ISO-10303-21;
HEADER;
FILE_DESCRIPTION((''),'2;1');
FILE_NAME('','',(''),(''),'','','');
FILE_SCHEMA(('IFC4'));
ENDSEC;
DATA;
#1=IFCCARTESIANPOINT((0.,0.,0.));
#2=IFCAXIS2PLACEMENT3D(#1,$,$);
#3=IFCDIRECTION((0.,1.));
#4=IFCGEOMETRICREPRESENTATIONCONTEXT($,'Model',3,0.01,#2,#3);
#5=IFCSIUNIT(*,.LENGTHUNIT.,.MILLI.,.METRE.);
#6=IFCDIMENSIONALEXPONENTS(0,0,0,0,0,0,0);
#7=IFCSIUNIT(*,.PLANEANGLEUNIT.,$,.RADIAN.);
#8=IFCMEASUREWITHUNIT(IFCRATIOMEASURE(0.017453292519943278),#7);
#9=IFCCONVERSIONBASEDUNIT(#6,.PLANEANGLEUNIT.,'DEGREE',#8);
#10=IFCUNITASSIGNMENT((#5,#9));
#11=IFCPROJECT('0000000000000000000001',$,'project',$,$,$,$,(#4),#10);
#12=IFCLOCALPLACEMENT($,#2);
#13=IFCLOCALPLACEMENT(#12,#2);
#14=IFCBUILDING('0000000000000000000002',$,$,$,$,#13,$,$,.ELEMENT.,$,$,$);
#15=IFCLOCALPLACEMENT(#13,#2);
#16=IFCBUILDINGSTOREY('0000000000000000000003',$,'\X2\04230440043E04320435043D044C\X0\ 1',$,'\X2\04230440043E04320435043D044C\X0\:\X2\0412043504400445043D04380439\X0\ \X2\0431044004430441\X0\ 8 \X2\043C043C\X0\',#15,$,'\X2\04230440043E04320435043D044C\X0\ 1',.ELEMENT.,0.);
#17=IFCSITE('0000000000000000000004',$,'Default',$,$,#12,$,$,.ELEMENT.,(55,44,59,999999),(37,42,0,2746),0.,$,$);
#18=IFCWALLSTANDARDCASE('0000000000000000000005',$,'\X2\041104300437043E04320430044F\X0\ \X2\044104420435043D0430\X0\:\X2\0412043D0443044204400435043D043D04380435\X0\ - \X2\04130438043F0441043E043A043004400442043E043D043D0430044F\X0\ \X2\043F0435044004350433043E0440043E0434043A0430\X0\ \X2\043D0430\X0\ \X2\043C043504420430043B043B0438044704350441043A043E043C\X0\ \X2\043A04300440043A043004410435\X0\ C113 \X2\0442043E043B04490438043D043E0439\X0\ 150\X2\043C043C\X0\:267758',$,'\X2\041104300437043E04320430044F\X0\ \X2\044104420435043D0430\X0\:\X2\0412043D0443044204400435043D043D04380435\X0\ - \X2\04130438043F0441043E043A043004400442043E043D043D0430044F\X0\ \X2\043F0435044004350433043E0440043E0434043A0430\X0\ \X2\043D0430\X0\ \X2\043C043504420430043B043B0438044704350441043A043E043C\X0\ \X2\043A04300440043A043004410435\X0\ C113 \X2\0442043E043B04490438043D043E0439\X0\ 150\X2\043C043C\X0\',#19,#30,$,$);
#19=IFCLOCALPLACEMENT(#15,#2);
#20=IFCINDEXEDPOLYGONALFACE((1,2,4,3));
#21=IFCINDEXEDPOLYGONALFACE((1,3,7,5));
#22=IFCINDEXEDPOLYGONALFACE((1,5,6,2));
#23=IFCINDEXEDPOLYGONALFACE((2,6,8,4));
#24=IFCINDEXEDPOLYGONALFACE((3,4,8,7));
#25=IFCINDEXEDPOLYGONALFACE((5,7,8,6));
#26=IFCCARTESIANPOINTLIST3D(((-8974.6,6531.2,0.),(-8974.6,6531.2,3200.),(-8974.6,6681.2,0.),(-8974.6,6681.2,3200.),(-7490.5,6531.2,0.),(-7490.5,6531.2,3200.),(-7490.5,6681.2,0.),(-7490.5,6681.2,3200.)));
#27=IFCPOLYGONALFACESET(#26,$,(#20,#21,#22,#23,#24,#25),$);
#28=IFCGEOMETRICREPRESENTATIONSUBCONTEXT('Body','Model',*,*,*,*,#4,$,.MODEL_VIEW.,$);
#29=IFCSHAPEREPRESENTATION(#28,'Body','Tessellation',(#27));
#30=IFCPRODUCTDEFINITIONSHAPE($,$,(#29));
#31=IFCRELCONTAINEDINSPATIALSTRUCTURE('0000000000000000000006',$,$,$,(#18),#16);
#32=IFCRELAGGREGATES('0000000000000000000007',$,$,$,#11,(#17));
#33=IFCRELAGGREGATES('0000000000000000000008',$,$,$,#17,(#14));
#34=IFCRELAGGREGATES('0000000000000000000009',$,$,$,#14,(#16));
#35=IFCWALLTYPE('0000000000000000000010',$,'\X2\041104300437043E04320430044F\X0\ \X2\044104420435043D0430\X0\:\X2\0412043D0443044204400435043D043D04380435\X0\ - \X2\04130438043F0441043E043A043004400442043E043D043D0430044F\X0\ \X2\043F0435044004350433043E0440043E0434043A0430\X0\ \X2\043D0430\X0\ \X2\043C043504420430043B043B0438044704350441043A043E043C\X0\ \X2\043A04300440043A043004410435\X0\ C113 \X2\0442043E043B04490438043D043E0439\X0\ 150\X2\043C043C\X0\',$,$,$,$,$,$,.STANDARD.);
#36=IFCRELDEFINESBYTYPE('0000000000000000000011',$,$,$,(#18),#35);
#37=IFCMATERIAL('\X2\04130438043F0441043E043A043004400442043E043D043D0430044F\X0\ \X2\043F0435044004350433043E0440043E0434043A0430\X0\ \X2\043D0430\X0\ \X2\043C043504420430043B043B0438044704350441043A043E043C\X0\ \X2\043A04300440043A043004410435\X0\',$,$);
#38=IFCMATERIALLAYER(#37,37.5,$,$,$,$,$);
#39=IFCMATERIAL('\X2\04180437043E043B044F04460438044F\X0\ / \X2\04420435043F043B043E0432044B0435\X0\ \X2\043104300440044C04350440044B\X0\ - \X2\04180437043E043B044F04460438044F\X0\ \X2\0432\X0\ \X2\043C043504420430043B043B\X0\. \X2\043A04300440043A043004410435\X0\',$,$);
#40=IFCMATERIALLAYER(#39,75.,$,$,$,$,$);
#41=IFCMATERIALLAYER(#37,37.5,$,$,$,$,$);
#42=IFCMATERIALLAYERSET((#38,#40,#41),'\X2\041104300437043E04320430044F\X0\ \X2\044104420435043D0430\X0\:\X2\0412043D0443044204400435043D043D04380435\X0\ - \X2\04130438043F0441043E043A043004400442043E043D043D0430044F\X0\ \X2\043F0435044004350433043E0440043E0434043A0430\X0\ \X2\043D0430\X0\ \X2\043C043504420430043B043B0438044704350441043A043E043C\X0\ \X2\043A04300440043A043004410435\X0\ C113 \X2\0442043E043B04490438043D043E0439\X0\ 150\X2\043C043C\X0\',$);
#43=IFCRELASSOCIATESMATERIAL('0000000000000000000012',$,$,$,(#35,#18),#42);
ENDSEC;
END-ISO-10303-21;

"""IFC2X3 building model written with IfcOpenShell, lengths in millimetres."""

from ifc_helpers import new_model, entity, si_unit, converted_unit, direction, frame, frame_2d, origin, place, context, subcontext, project, spatial, rectangle, extrude, material, layer, layer_set, layer_usage, type_object, element, save


model = new_model("IFC2X3")

# Units and contexts
model_context = context("Model", 3, precision=0.01, world=origin(), true_north=direction((0.0, 1.0)))
body_context = subcontext(model_context, "Body", "Model", "MODEL_VIEW")
ifc_project = project(units=[si_unit("LENGTHUNIT", "METRE", prefix="MILLI"), converted_unit("PLANEANGLEUNIT", "DEGREE", entity("IfcRatioMeasure", 0.017453292519943278), si_unit("PLANEANGLEUNIT", "RADIAN"), dimensions=[0, 0, 0, 0, 0, 0, 0])], contexts=[model_context])

# Site, building, storey
site_placement = place(None, origin())
site = spatial("IfcSite", under=ifc_project, at=site_placement, Name="Default", CompositionType="ELEMENT", RefLatitude=(55, 44, 59, 999999), RefLongitude=(37, 42, 0, 2746), RefElevation=0.0)
building_placement = place(site_placement, origin())
building = spatial("IfcBuilding", under=site, at=building_placement, CompositionType="ELEMENT")
storey_placement = place(building_placement, origin())
storey = spatial("IfcBuildingStorey", under=building, at=storey_placement, Name="Уровень 1", ObjectType="Уровень:Верхний брус 8 мм", LongName="Уровень 1", CompositionType="ELEMENT", Elevation=0.0)

# Shared definitions
ifc_material_1 = material(Name="Гипсокартонная перегородка на металлическом каркасе")
ifc_layer_1 = layer(ifc_material_1, 37.5)
ifc_material_2 = material(Name="Изоляция / тепловые барьеры - Изоляция в металл. каркасе")
ifc_layer_2 = layer(ifc_material_2, 75.0)
ifc_layer_3 = layer(ifc_material_1, 37.5)
ifc_layer_set_1 = layer_set([ifc_layer_1, ifc_layer_2, ifc_layer_3], Name="Базовая стена:Внутренние - Гипсокартонная перегородка на металлическом каркасе C113 толщиной 150мм")
wall_type_1 = type_object("IfcWallType", Name="Базовая стена:Внутренние - Гипсокартонная перегородка на металлическом каркасе C113 толщиной 150мм", PredefinedType="STANDARD", material=ifc_layer_set_1)

# Wall
ifc_layer_usage_1 = layer_usage(ifc_layer_set_1, "AXIS2", "NEGATIVE", 75.0)
wall_1_placement = place(storey_placement, frame((-8974.6, 6606.2, 0.0)))
element("IfcWallStandardCase", 1, at=wall_1_placement, inside=storey, type_object=wall_type_1, material=ifc_layer_usage_1, Name="Базовая стена:Внутренние - Гипсокартонная перегородка на металлическом каркасе C113 толщиной 150мм:267758", ObjectType="Базовая стена:Внутренние - Гипсокартонная перегородка на металлическом каркасе C113 толщиной 150мм", context=body_context, shape_type="SweptSolid", body=[
    extrude(rectangle(XDim=1484.1, YDim=150.0, at=frame_2d((742.1, 0.0), x_axis=(-1.0, 0.0))), origin(), (0.0, 0.0, 1.0), 3200.0),
])

save(model, "model.ifc")
